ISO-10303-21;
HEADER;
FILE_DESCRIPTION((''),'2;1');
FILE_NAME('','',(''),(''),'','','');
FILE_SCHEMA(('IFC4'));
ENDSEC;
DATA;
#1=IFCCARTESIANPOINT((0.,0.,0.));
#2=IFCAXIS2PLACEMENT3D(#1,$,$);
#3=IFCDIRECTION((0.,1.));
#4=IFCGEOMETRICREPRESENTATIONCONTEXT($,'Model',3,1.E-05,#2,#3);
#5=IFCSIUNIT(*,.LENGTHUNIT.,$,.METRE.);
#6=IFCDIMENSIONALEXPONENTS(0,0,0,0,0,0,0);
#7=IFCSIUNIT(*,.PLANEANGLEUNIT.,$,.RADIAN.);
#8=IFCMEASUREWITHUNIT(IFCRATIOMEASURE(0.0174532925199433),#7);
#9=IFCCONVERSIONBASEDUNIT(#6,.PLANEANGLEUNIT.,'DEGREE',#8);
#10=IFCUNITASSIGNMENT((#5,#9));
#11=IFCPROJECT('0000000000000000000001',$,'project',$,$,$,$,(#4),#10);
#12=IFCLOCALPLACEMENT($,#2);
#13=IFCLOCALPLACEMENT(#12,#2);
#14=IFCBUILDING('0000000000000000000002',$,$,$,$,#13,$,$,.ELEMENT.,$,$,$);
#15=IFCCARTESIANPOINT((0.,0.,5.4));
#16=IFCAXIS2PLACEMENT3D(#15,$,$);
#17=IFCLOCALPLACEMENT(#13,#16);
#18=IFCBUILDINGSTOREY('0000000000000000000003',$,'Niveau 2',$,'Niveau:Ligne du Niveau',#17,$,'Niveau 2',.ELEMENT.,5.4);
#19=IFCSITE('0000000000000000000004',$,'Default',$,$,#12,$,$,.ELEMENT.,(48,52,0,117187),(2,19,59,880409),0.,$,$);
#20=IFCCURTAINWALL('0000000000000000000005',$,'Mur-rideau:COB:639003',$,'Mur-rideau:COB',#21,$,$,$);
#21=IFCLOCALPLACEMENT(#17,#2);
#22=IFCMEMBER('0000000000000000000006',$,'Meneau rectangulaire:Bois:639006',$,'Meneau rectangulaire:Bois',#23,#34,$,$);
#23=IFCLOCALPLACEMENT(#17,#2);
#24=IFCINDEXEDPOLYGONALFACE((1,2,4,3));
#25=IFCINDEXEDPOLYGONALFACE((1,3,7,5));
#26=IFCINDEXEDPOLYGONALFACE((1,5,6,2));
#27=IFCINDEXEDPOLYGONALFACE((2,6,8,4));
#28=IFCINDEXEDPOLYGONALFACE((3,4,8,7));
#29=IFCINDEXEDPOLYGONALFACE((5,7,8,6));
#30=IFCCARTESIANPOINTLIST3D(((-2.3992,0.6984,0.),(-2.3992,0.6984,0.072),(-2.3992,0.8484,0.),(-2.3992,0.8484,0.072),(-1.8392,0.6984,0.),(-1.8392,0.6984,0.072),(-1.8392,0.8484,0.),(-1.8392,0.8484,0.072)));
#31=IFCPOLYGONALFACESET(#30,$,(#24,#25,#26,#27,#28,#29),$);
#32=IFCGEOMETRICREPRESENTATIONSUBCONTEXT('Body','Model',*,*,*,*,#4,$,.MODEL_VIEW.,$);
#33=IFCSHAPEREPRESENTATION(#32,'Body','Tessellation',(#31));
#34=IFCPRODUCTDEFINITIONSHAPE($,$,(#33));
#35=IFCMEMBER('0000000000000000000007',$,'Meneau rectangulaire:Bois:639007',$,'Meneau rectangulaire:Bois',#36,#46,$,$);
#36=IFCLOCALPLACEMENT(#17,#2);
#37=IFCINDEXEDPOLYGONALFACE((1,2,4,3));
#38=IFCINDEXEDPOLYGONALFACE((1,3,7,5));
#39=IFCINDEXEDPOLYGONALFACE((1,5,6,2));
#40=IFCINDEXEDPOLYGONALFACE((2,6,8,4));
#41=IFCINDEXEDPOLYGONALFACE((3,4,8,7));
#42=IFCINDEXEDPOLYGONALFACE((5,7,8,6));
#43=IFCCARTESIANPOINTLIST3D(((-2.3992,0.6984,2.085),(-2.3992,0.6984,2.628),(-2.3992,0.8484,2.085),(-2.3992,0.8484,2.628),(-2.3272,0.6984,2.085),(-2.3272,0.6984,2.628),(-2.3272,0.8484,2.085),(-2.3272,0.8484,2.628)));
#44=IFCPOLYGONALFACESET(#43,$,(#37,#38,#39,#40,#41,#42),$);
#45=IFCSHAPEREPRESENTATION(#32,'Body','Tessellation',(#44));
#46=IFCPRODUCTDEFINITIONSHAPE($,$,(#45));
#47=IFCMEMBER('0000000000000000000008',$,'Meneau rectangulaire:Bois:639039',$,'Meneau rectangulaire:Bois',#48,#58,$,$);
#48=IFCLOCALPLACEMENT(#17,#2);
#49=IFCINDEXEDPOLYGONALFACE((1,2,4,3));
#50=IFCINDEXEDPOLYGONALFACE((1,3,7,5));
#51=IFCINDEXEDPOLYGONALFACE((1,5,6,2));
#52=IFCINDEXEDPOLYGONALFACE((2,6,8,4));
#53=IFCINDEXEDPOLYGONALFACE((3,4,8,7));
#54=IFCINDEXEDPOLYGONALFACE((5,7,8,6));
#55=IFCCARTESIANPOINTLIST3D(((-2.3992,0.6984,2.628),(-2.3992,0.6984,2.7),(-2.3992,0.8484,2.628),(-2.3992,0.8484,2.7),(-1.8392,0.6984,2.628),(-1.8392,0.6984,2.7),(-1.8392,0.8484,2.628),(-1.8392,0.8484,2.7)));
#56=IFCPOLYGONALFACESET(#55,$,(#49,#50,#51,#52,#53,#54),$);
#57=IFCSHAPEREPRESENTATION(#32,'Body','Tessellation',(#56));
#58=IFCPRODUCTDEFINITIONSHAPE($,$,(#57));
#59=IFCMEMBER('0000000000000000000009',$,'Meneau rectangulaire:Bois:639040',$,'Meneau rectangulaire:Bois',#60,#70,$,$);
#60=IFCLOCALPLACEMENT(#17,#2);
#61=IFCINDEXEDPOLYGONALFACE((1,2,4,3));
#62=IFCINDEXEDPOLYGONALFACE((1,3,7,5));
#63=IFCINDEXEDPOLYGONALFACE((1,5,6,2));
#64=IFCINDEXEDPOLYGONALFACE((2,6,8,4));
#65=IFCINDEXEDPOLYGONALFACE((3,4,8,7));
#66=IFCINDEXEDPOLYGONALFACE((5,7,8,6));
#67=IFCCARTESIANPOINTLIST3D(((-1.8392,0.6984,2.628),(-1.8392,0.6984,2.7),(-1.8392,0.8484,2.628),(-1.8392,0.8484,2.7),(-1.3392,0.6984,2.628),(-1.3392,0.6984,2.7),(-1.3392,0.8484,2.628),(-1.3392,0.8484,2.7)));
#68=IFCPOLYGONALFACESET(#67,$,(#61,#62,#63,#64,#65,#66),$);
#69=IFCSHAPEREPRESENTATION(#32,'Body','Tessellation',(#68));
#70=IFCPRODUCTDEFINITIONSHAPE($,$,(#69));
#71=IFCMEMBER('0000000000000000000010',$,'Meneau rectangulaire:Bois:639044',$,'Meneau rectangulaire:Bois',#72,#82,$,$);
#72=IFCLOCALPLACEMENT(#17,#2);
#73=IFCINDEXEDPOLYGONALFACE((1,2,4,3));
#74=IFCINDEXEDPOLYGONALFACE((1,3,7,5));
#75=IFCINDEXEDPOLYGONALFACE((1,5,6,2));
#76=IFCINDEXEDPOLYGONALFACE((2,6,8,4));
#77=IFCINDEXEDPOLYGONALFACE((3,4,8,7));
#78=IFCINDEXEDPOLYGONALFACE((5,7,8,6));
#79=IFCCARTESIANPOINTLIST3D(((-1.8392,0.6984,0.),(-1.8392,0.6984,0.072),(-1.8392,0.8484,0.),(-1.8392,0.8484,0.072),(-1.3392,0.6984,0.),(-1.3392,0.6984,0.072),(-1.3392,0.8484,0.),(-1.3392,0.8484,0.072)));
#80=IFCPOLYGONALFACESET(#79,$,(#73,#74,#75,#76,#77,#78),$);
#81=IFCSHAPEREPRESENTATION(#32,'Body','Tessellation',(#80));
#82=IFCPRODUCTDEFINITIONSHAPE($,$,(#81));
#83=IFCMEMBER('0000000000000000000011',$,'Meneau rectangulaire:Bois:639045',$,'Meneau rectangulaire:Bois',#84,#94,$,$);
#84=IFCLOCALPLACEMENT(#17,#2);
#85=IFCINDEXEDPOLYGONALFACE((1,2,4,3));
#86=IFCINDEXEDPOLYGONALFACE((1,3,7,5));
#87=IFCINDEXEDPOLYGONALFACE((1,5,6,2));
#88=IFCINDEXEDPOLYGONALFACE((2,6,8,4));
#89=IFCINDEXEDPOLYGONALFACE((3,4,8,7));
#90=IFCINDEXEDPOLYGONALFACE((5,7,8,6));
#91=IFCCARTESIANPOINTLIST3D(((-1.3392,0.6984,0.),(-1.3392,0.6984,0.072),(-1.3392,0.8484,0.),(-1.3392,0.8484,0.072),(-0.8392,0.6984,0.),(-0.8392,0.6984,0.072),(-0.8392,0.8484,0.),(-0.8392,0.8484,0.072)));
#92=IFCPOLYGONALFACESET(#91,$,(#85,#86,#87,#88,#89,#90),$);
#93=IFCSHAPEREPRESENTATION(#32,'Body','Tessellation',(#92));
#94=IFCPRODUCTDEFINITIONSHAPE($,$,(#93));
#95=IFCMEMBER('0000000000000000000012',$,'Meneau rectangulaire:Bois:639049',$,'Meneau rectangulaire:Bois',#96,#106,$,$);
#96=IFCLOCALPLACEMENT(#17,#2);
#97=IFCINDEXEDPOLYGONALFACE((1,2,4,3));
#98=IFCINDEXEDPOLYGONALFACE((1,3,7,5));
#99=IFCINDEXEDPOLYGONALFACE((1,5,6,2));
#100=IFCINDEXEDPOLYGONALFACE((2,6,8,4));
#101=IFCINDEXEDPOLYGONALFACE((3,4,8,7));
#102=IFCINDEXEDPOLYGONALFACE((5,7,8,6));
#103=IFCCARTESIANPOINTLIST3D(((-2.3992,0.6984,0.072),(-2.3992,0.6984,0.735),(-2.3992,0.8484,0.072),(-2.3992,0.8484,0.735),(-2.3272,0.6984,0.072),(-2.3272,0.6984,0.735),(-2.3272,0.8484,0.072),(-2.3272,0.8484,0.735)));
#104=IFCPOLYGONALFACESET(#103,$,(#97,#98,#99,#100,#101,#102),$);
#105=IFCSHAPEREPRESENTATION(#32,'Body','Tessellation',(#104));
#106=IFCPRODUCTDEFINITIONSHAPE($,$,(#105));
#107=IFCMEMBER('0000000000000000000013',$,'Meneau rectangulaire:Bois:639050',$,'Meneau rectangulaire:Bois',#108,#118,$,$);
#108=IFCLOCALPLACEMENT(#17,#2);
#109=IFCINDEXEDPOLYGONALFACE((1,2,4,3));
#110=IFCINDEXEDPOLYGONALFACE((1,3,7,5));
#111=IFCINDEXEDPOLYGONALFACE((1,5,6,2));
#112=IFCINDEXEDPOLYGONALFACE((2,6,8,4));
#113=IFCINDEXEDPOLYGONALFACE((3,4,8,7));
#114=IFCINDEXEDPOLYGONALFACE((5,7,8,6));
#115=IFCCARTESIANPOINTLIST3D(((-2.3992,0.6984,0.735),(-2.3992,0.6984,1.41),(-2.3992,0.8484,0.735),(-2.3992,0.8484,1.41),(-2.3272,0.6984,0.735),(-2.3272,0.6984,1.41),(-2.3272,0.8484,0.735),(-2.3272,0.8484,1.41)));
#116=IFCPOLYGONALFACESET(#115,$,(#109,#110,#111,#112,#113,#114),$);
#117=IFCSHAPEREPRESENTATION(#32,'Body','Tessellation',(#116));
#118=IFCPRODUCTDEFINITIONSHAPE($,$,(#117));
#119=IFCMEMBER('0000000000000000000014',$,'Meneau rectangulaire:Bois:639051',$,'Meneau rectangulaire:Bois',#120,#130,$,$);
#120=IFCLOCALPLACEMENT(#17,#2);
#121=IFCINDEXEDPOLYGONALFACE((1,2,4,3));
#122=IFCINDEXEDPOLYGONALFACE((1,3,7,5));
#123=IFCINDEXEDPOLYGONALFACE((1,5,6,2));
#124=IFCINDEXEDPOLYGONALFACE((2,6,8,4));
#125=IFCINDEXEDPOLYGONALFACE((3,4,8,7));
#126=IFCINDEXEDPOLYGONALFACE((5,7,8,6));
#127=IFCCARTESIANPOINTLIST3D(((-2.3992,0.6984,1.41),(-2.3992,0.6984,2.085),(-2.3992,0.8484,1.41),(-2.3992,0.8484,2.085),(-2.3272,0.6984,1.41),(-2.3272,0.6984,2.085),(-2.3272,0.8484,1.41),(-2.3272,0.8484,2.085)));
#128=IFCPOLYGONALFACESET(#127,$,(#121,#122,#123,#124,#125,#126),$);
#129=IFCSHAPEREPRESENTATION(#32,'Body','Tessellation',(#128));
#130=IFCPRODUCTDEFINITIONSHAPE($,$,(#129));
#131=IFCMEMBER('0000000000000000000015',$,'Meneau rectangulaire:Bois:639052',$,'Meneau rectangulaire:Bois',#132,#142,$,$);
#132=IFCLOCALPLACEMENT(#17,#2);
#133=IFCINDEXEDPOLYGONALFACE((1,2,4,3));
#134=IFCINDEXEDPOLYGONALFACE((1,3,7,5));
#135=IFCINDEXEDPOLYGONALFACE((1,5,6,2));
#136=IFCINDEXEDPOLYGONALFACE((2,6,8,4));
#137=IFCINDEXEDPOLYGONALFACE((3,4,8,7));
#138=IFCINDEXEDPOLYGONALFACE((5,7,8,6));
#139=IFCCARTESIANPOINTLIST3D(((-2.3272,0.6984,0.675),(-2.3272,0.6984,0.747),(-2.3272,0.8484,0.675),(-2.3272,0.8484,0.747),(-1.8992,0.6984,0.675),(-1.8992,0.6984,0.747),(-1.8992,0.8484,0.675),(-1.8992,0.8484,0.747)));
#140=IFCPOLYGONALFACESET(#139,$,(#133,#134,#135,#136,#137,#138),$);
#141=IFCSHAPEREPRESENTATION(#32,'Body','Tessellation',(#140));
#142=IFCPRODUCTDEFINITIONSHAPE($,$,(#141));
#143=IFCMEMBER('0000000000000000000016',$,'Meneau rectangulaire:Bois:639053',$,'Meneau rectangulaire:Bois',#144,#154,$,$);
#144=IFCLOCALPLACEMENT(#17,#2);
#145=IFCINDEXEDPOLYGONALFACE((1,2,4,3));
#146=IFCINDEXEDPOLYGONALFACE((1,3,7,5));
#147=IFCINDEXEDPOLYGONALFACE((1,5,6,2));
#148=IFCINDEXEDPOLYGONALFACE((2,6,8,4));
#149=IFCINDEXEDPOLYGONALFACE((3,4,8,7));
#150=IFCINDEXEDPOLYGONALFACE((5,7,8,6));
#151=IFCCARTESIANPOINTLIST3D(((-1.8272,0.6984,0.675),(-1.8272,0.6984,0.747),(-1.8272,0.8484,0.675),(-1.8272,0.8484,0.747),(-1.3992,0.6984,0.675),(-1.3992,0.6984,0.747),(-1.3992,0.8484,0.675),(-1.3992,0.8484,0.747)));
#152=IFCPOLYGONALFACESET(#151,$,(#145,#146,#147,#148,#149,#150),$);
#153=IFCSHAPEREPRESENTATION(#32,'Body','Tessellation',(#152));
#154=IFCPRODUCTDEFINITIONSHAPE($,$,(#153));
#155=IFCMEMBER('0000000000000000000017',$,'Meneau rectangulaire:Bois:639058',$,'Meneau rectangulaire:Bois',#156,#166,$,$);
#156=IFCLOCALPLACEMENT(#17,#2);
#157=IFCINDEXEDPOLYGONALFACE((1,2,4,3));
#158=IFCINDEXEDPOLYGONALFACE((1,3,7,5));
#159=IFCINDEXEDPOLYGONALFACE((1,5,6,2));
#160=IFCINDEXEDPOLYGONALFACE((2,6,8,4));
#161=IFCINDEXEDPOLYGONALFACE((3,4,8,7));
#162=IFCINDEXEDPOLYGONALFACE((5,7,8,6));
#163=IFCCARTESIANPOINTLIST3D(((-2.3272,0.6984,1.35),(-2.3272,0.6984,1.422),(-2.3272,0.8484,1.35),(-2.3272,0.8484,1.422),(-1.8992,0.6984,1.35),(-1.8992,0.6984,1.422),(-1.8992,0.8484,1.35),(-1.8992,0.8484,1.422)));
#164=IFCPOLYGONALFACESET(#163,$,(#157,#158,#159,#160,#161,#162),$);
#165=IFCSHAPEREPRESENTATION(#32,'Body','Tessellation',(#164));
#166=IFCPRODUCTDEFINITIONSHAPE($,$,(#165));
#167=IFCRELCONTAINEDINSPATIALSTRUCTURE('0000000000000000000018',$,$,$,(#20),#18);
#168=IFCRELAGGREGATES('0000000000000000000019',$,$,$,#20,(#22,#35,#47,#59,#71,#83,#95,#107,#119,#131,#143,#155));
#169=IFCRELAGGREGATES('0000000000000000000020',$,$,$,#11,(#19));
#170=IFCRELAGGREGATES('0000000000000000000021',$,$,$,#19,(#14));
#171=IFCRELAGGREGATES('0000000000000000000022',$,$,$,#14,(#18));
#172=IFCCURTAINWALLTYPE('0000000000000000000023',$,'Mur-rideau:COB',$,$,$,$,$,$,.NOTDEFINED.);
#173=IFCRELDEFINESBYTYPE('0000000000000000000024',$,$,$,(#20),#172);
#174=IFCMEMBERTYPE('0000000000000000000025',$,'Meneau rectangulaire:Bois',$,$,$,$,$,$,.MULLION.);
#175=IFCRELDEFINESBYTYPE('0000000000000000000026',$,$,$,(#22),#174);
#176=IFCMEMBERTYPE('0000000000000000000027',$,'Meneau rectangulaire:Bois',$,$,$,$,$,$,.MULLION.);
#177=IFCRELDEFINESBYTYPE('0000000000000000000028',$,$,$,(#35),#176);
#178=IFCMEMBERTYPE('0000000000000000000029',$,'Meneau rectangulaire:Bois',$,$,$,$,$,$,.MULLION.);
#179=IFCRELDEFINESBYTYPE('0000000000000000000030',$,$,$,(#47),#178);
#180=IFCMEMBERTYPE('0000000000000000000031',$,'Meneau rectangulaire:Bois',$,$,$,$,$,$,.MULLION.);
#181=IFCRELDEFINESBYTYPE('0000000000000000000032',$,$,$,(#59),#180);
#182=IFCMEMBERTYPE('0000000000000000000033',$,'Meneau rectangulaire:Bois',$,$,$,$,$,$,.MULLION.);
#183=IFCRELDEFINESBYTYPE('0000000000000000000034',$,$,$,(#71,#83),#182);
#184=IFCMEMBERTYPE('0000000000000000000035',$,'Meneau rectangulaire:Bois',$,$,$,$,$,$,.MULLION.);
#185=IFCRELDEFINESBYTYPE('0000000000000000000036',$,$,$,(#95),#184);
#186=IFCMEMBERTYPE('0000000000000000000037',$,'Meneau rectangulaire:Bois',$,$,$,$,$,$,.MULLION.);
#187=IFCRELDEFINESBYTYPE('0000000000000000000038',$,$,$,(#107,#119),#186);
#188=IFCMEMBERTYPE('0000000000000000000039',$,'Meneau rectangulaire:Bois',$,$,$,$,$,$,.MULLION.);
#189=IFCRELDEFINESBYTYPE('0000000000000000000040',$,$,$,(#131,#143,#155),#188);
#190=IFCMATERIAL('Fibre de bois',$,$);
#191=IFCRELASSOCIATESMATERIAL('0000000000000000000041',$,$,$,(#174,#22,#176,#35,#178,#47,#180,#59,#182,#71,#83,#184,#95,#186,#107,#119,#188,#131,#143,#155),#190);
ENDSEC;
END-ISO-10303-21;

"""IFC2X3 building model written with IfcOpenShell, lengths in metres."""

from ifc_helpers import new_model, entity, si_unit, converted_unit, direction, frame, origin, origin_2d_with_axis, place, context, subcontext, project, spatial, rectangle, extrude, source, transform, mapped, material, type_object, type_shapes, element, aggregate, save


model = new_model("IFC2X3")

# Units and contexts
model_context = context("Model", 3, precision=1e-05, world=origin(), true_north=direction((0.0, 1.0)))
body_context = subcontext(model_context, "Body", "Model", "MODEL_VIEW")
ifc_project = project(units=[si_unit("LENGTHUNIT", "METRE"), converted_unit("PLANEANGLEUNIT", "DEGREE", entity("IfcRatioMeasure", 0.0174532925199433), si_unit("PLANEANGLEUNIT", "RADIAN"), dimensions=[0, 0, 0, 0, 0, 0, 0])], contexts=[model_context])

# Site, building, storey
site_placement = place(None, origin())
site = spatial("IfcSite", under=ifc_project, at=site_placement, Name="Default", CompositionType="ELEMENT", RefLatitude=(48, 52, 0, 117187), RefLongitude=(2, 19, 59, 880409), RefElevation=0.0)
building_placement = place(site_placement, origin())
building = spatial("IfcBuilding", under=site, at=building_placement, CompositionType="ELEMENT")
storey_placement = place(building_placement, frame((0.0, 0.0, 5.4)))
storey = spatial("IfcBuildingStorey", under=building, at=storey_placement, Name="Niveau 2", ObjectType="Niveau:Ligne du Niveau", LongName="Niveau 2", CompositionType="ELEMENT", Elevation=5.4)

# Curtain wall, members
curtain_wall_type_1 = type_object("IfcCurtainWallType", Name="Mur-rideau:COB", PredefinedType="NOTDEFINED")
curtain_wall_1_placement = place(storey_placement, frame((0.0, 0.0, -5.4)))
curtain_wall_1 = element("IfcCurtainWall", 1, at=curtain_wall_1_placement, inside=storey, type_object=curtain_wall_type_1, Name="Mur-rideau:COB:639003", ObjectType="Mur-rideau:COB")
ifc_material_1 = material(Name="Fibre de bois")
member_type_1 = type_object("IfcMemberType", Name="Meneau rectangulaire:Bois", PredefinedType="MULLION", material=ifc_material_1)
shared_shape_1 = source(origin(), body_context, "Body", "SweptSolid", [
    extrude(rectangle(XDim=0.15, YDim=0.072, at=origin_2d_with_axis()), frame((-0.036, 0.0, -0.56), z_axis=(0.0, 0.0, 1.0), x_axis=(0.0, -1.0, 0.0)), (0.0, 0.0, 1.0), 0.56),
])
type_shapes(member_type_1, [shared_shape_1])
member_1_placement = place(storey_placement, frame((-2.3992, 0.7734, 0.0), z_axis=(-1.0, 0.0, 0.0), x_axis=(0.0, 0.0, -1.0)))
member_1 = element("IfcMember", 2, at=member_1_placement, type_object=member_type_1, material=ifc_material_1, Name="Meneau rectangulaire:Bois:639006", ObjectType="Meneau rectangulaire:Bois", context=body_context, shape_type="MappedRepresentation", body=[
    mapped(shared_shape_1, transform((0.0, 0.0, 0.0), scale=1.0)),
])
member_type_2 = type_object("IfcMemberType", Name="Meneau rectangulaire:Bois", PredefinedType="MULLION", material=ifc_material_1)
shared_shape_2 = source(origin(), body_context, "Body", "SweptSolid", [
    extrude(rectangle(XDim=0.15, YDim=0.072, at=origin_2d_with_axis()), frame((-0.036, 0.0, -0.543), z_axis=(0.0, 0.0, 1.0), x_axis=(0.0, -1.0, 0.0)), (0.0, 0.0, 1.0), 0.543),
])
type_shapes(member_type_2, [shared_shape_2])
member_2_placement = place(storey_placement, frame((-2.3992, 0.7734, 2.628), z_axis=(0.0, 0.0, 1.0), x_axis=(-1.0, 0.0, 0.0)))
member_2 = element("IfcMember", 3, at=member_2_placement, type_object=member_type_2, material=ifc_material_1, Name="Meneau rectangulaire:Bois:639007", ObjectType="Meneau rectangulaire:Bois", context=body_context, shape_type="MappedRepresentation", body=[
    mapped(shared_shape_2, transform((0.0, 0.0, 0.0), scale=1.0)),
])
member_type_3 = type_object("IfcMemberType", Name="Meneau rectangulaire:Bois", PredefinedType="MULLION", material=ifc_material_1)
shared_shape_3 = source(origin(), body_context, "Body", "SweptSolid", [
    extrude(rectangle(XDim=0.15, YDim=0.072, at=origin_2d_with_axis()), frame((-0.036, 0.0, -0.56), z_axis=(0.0, 0.0, 1.0), x_axis=(0.0, -1.0, 0.0)), (0.0, 0.0, 1.0), 0.56),
])
type_shapes(member_type_3, [shared_shape_3])
member_3_placement = place(storey_placement, frame((-1.8392, 0.7734, 2.7), z_axis=(1.0, 0.0, 0.0), x_axis=(0.0, 0.0, 1.0)))
member_3 = element("IfcMember", 4, at=member_3_placement, type_object=member_type_3, material=ifc_material_1, Name="Meneau rectangulaire:Bois:639039", ObjectType="Meneau rectangulaire:Bois", context=body_context, shape_type="MappedRepresentation", body=[
    mapped(shared_shape_3, transform((0.0, 0.0, 0.0), scale=1.0)),
])
member_type_4 = type_object("IfcMemberType", Name="Meneau rectangulaire:Bois", PredefinedType="MULLION", material=ifc_material_1)
shared_shape_4 = source(origin(), body_context, "Body", "SweptSolid", [
    extrude(rectangle(XDim=0.15, YDim=0.072, at=origin_2d_with_axis()), frame((-0.036, 0.0, -0.5), z_axis=(0.0, 0.0, 1.0), x_axis=(0.0, -1.0, 0.0)), (0.0, 0.0, 1.0), 0.5),
])
type_shapes(member_type_4, [shared_shape_4])
member_4_placement = place(storey_placement, frame((-1.3392, 0.7734, 2.7), z_axis=(1.0, 0.0, 0.0), x_axis=(0.0, 0.0, 1.0)))
member_4 = element("IfcMember", 5, at=member_4_placement, type_object=member_type_4, material=ifc_material_1, Name="Meneau rectangulaire:Bois:639040", ObjectType="Meneau rectangulaire:Bois", context=body_context, shape_type="MappedRepresentation", body=[
    mapped(shared_shape_4, transform((0.0, 0.0, 0.0), scale=1.0)),
])
member_type_5 = type_object("IfcMemberType", Name="Meneau rectangulaire:Bois", PredefinedType="MULLION", material=ifc_material_1)
shared_shape_5 = source(origin(), body_context, "Body", "SweptSolid", [
    extrude(rectangle(XDim=0.15, YDim=0.072, at=origin_2d_with_axis()), frame((-0.036, 0.0, -0.5), z_axis=(0.0, 0.0, 1.0), x_axis=(0.0, -1.0, 0.0)), (0.0, 0.0, 1.0), 0.5),
])
type_shapes(member_type_5, [shared_shape_5])
member_5_placement = place(storey_placement, frame((-1.8392, 0.7734, 0.0), z_axis=(-1.0, 0.0, 0.0), x_axis=(0.0, 0.0, -1.0)))
member_5 = element("IfcMember", 6, at=member_5_placement, type_object=member_type_5, material=ifc_material_1, Name="Meneau rectangulaire:Bois:639044", ObjectType="Meneau rectangulaire:Bois", context=body_context, shape_type="MappedRepresentation", body=[
    mapped(shared_shape_5, transform((0.0, 0.0, 0.0), scale=1.0)),
])
member_6_placement = place(storey_placement, frame((-1.3392, 0.7734, 0.0), z_axis=(-1.0, 0.0, 0.0), x_axis=(0.0, 0.0, -1.0)))
member_6 = element("IfcMember", 7, at=member_6_placement, type_object=member_type_5, material=ifc_material_1, Name="Meneau rectangulaire:Bois:639045", ObjectType="Meneau rectangulaire:Bois", context=body_context, shape_type="MappedRepresentation", body=[
    mapped(shared_shape_5, transform((0.0, 0.0, 0.0), scale=1.0)),
])
member_type_6 = type_object("IfcMemberType", Name="Meneau rectangulaire:Bois", PredefinedType="MULLION", material=ifc_material_1)
shared_shape_6 = source(origin(), body_context, "Body", "SweptSolid", [
    extrude(rectangle(XDim=0.15, YDim=0.072, at=origin_2d_with_axis()), frame((-0.036, 0.0, -0.663), z_axis=(0.0, 0.0, 1.0), x_axis=(0.0, -1.0, 0.0)), (0.0, 0.0, 1.0), 0.663),
])
type_shapes(member_type_6, [shared_shape_6])
member_7_placement = place(storey_placement, frame((-2.3992, 0.7734, 0.735), z_axis=(0.0, 0.0, 1.0), x_axis=(-1.0, 0.0, 0.0)))
member_7 = element("IfcMember", 8, at=member_7_placement, type_object=member_type_6, material=ifc_material_1, Name="Meneau rectangulaire:Bois:639049", ObjectType="Meneau rectangulaire:Bois", context=body_context, shape_type="MappedRepresentation", body=[
    mapped(shared_shape_6, transform((0.0, 0.0, 0.0), scale=1.0)),
])
member_type_7 = type_object("IfcMemberType", Name="Meneau rectangulaire:Bois", PredefinedType="MULLION", material=ifc_material_1)
shared_shape_7 = source(origin(), body_context, "Body", "SweptSolid", [
    extrude(rectangle(XDim=0.15, YDim=0.072, at=origin_2d_with_axis()), frame((-0.036, 0.0, -0.675), z_axis=(0.0, 0.0, 1.0), x_axis=(0.0, -1.0, 0.0)), (0.0, 0.0, 1.0), 0.675),
])
type_shapes(member_type_7, [shared_shape_7])
member_8_placement = place(storey_placement, frame((-2.3992, 0.7734, 1.41), z_axis=(0.0, 0.0, 1.0), x_axis=(-1.0, 0.0, 0.0)))
member_8 = element("IfcMember", 9, at=member_8_placement, type_object=member_type_7, material=ifc_material_1, Name="Meneau rectangulaire:Bois:639050", ObjectType="Meneau rectangulaire:Bois", context=body_context, shape_type="MappedRepresentation", body=[
    mapped(shared_shape_7, transform((0.0, 0.0, 0.0), scale=1.0)),
])
member_9_placement = place(storey_placement, frame((-2.3992, 0.7734, 2.085), z_axis=(0.0, 0.0, 1.0), x_axis=(-1.0, 0.0, 0.0)))
member_9 = element("IfcMember", 10, at=member_9_placement, type_object=member_type_7, material=ifc_material_1, Name="Meneau rectangulaire:Bois:639051", ObjectType="Meneau rectangulaire:Bois", context=body_context, shape_type="MappedRepresentation", body=[
    mapped(shared_shape_7, transform((0.0, 0.0, 0.0), scale=1.0)),
])
member_type_8 = type_object("IfcMemberType", Name="Meneau rectangulaire:Bois", PredefinedType="MULLION", material=ifc_material_1)
shared_shape_8 = source(origin(), body_context, "Body", "SweptSolid", [
    extrude(rectangle(XDim=0.15, YDim=0.072, at=origin_2d_with_axis()), frame((-0.024, 0.0, -0.428), z_axis=(0.0, 0.0, 1.0), x_axis=(0.0, -1.0, 0.0)), (0.0, 0.0, 1.0), 0.428),
])
type_shapes(member_type_8, [shared_shape_8])
member_10_placement = place(storey_placement, frame((-1.8992, 0.7734, 0.735), z_axis=(1.0, 0.0, 0.0), x_axis=(0.0, 0.0, 1.0)))
member_10 = element("IfcMember", 11, at=member_10_placement, type_object=member_type_8, material=ifc_material_1, Name="Meneau rectangulaire:Bois:639052", ObjectType="Meneau rectangulaire:Bois", context=body_context, shape_type="MappedRepresentation", body=[
    mapped(shared_shape_8, transform((0.0, 0.0, 0.0), scale=1.0)),
])
member_11_placement = place(storey_placement, frame((-1.3992, 0.7734, 0.735), z_axis=(1.0, 0.0, 0.0), x_axis=(0.0, 0.0, 1.0)))
member_11 = element("IfcMember", 12, at=member_11_placement, type_object=member_type_8, material=ifc_material_1, Name="Meneau rectangulaire:Bois:639053", ObjectType="Meneau rectangulaire:Bois", context=body_context, shape_type="MappedRepresentation", body=[
    mapped(shared_shape_8, transform((0.0, 0.0, 0.0), scale=1.0)),
])
member_12_placement = place(storey_placement, frame((-1.8992, 0.7734, 1.41), z_axis=(1.0, 0.0, 0.0), x_axis=(0.0, 0.0, 1.0)))
member_12 = element("IfcMember", 13, at=member_12_placement, type_object=member_type_8, material=ifc_material_1, Name="Meneau rectangulaire:Bois:639058", ObjectType="Meneau rectangulaire:Bois", context=body_context, shape_type="MappedRepresentation", body=[
    mapped(shared_shape_8, transform((0.0, 0.0, 0.0), scale=1.0)),
])
aggregate(curtain_wall_1, [member_1, member_2, member_3, member_4, member_5, member_6, member_7, member_8, member_9, member_10, member_11, member_12])

save(model, "model.ifc")
